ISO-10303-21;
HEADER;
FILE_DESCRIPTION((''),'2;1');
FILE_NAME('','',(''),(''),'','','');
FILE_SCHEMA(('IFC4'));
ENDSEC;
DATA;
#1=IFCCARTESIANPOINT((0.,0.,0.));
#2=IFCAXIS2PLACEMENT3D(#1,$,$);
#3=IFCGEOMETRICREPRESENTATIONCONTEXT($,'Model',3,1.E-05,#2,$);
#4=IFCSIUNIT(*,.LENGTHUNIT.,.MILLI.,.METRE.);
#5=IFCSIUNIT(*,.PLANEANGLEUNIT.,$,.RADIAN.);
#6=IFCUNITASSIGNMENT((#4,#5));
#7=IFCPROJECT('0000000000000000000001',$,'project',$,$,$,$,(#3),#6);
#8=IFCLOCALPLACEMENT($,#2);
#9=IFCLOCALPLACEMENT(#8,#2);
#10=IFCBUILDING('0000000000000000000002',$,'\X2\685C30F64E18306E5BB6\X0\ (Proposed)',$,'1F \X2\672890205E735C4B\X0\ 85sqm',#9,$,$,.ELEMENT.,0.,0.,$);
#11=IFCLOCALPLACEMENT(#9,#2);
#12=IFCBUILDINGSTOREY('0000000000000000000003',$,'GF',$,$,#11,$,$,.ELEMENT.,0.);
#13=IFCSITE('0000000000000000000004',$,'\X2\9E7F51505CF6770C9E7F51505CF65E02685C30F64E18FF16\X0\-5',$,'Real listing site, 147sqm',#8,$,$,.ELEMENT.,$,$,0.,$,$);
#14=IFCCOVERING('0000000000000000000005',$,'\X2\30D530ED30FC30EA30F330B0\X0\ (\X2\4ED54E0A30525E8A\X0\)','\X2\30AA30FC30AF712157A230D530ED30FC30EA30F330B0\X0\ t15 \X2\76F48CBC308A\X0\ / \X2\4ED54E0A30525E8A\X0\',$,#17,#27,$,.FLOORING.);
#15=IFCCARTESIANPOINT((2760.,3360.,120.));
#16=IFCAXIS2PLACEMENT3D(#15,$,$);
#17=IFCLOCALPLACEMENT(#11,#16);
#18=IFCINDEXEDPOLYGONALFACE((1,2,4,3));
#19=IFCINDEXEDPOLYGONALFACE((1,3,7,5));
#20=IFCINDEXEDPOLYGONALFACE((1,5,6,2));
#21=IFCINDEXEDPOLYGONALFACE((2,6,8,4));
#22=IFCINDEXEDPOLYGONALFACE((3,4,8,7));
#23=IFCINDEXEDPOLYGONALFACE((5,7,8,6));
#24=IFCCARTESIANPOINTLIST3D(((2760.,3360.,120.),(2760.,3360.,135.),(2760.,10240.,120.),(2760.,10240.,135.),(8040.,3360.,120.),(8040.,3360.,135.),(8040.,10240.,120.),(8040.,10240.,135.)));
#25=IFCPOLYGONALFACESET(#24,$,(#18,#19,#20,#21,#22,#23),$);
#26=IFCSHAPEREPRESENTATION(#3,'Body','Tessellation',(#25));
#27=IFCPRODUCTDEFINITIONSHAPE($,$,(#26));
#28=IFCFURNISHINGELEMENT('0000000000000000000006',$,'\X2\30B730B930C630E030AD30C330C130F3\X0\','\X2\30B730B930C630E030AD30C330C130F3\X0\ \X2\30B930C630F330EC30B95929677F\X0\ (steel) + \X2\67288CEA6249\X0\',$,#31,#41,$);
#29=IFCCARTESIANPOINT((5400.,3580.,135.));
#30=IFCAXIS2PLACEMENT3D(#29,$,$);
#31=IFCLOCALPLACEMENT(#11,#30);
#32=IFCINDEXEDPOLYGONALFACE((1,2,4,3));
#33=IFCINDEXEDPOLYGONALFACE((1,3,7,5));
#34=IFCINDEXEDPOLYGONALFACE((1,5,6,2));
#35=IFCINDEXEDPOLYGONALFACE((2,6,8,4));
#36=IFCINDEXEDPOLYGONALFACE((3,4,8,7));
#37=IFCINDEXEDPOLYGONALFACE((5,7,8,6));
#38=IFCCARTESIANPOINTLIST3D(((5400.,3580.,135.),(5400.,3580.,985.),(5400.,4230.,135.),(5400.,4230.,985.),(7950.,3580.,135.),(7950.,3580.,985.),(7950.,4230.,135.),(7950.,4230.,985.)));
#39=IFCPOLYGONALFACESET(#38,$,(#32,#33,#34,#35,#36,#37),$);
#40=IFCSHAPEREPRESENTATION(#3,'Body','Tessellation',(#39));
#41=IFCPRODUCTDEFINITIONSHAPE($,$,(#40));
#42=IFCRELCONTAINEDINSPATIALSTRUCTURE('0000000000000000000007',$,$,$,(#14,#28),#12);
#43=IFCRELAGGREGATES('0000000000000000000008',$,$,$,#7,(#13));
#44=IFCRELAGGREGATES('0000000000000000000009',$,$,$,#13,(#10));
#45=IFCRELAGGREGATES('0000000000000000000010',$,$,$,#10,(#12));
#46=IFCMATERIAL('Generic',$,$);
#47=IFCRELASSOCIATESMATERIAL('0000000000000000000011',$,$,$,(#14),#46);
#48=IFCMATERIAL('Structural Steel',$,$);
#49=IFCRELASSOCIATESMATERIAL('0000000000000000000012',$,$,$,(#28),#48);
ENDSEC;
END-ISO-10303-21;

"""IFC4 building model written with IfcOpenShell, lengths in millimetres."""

from ifc_helpers import new_model, si_unit, frame, frame_2d, origin, place, context, project, spatial, rectangle, extrude, material, element, save


model = new_model("IFC4")

# Units and contexts
model_context = context("Model", 3, precision=1e-05, world=origin())
ifc_project = project(units=[si_unit("LENGTHUNIT", "METRE", prefix="MILLI"), si_unit("PLANEANGLEUNIT", "RADIAN")], contexts=[model_context])

# Site, building, storey
site_placement = place(None, origin())
site = spatial("IfcSite", under=ifc_project, at=site_placement, Name="鹿児島県鹿児島市桜ヶ丘６-5", ObjectType="Real listing site, 147sqm", CompositionType="ELEMENT", RefElevation=0.0)
building_placement = place(site_placement, origin())
building = spatial("IfcBuilding", under=site, at=building_placement, Name="桜ヶ丘の家 (Proposed)", ObjectType="1F 木造平屋 85sqm", CompositionType="ELEMENT", ElevationOfRefHeight=0.0, ElevationOfTerrain=0.0)
storey_placement = place(building_placement, origin())
storey = spatial("IfcBuildingStorey", under=building, at=storey_placement, Name="GF", CompositionType="ELEMENT", Elevation=0.0)

# Shared definitions
ifc_material_1 = material(Name="Generic")

# Covering
covering_placement = place(storey_placement, frame((2760.0, 3360.0, 120.0)))
element("IfcCovering", 1, at=covering_placement, inside=storey, material=ifc_material_1, Name="フローリング (仕上げ床)", Description="オーク無垢フローリング t15 直貼り / 仕上げ床", PredefinedType="FLOORING", context=model_context, shape_type="SweptSolid", body=[
    extrude(rectangle(XDim=5280.0, YDim=6880.0, at=frame_2d((2640.0, 3440.0))), frame((2760.0, 3360.0, 120.0)), (0.0, 0.0, 1.0), 15.0),
])

# Furnishing element
ifc_material_2 = material(Name="Structural Steel")
furnishing_placement = place(storey_placement, frame((5400.0, 3580.0, 135.0)))
element("IfcFurnishingElement", 2, at=furnishing_placement, inside=storey, material=ifc_material_2, Name="システムキッチン", Description="システムキッチン ステンレス天板 (steel) + 木質扉", context=model_context, shape_type="SweptSolid", body=[
    extrude(rectangle(XDim=2550.0, YDim=650.0, at=frame_2d((1275.0, 325.0))), frame((5400.0, 3580.0, 135.0)), (0.0, 0.0, 1.0), 850.0),
])

save(model, "model.ifc")
